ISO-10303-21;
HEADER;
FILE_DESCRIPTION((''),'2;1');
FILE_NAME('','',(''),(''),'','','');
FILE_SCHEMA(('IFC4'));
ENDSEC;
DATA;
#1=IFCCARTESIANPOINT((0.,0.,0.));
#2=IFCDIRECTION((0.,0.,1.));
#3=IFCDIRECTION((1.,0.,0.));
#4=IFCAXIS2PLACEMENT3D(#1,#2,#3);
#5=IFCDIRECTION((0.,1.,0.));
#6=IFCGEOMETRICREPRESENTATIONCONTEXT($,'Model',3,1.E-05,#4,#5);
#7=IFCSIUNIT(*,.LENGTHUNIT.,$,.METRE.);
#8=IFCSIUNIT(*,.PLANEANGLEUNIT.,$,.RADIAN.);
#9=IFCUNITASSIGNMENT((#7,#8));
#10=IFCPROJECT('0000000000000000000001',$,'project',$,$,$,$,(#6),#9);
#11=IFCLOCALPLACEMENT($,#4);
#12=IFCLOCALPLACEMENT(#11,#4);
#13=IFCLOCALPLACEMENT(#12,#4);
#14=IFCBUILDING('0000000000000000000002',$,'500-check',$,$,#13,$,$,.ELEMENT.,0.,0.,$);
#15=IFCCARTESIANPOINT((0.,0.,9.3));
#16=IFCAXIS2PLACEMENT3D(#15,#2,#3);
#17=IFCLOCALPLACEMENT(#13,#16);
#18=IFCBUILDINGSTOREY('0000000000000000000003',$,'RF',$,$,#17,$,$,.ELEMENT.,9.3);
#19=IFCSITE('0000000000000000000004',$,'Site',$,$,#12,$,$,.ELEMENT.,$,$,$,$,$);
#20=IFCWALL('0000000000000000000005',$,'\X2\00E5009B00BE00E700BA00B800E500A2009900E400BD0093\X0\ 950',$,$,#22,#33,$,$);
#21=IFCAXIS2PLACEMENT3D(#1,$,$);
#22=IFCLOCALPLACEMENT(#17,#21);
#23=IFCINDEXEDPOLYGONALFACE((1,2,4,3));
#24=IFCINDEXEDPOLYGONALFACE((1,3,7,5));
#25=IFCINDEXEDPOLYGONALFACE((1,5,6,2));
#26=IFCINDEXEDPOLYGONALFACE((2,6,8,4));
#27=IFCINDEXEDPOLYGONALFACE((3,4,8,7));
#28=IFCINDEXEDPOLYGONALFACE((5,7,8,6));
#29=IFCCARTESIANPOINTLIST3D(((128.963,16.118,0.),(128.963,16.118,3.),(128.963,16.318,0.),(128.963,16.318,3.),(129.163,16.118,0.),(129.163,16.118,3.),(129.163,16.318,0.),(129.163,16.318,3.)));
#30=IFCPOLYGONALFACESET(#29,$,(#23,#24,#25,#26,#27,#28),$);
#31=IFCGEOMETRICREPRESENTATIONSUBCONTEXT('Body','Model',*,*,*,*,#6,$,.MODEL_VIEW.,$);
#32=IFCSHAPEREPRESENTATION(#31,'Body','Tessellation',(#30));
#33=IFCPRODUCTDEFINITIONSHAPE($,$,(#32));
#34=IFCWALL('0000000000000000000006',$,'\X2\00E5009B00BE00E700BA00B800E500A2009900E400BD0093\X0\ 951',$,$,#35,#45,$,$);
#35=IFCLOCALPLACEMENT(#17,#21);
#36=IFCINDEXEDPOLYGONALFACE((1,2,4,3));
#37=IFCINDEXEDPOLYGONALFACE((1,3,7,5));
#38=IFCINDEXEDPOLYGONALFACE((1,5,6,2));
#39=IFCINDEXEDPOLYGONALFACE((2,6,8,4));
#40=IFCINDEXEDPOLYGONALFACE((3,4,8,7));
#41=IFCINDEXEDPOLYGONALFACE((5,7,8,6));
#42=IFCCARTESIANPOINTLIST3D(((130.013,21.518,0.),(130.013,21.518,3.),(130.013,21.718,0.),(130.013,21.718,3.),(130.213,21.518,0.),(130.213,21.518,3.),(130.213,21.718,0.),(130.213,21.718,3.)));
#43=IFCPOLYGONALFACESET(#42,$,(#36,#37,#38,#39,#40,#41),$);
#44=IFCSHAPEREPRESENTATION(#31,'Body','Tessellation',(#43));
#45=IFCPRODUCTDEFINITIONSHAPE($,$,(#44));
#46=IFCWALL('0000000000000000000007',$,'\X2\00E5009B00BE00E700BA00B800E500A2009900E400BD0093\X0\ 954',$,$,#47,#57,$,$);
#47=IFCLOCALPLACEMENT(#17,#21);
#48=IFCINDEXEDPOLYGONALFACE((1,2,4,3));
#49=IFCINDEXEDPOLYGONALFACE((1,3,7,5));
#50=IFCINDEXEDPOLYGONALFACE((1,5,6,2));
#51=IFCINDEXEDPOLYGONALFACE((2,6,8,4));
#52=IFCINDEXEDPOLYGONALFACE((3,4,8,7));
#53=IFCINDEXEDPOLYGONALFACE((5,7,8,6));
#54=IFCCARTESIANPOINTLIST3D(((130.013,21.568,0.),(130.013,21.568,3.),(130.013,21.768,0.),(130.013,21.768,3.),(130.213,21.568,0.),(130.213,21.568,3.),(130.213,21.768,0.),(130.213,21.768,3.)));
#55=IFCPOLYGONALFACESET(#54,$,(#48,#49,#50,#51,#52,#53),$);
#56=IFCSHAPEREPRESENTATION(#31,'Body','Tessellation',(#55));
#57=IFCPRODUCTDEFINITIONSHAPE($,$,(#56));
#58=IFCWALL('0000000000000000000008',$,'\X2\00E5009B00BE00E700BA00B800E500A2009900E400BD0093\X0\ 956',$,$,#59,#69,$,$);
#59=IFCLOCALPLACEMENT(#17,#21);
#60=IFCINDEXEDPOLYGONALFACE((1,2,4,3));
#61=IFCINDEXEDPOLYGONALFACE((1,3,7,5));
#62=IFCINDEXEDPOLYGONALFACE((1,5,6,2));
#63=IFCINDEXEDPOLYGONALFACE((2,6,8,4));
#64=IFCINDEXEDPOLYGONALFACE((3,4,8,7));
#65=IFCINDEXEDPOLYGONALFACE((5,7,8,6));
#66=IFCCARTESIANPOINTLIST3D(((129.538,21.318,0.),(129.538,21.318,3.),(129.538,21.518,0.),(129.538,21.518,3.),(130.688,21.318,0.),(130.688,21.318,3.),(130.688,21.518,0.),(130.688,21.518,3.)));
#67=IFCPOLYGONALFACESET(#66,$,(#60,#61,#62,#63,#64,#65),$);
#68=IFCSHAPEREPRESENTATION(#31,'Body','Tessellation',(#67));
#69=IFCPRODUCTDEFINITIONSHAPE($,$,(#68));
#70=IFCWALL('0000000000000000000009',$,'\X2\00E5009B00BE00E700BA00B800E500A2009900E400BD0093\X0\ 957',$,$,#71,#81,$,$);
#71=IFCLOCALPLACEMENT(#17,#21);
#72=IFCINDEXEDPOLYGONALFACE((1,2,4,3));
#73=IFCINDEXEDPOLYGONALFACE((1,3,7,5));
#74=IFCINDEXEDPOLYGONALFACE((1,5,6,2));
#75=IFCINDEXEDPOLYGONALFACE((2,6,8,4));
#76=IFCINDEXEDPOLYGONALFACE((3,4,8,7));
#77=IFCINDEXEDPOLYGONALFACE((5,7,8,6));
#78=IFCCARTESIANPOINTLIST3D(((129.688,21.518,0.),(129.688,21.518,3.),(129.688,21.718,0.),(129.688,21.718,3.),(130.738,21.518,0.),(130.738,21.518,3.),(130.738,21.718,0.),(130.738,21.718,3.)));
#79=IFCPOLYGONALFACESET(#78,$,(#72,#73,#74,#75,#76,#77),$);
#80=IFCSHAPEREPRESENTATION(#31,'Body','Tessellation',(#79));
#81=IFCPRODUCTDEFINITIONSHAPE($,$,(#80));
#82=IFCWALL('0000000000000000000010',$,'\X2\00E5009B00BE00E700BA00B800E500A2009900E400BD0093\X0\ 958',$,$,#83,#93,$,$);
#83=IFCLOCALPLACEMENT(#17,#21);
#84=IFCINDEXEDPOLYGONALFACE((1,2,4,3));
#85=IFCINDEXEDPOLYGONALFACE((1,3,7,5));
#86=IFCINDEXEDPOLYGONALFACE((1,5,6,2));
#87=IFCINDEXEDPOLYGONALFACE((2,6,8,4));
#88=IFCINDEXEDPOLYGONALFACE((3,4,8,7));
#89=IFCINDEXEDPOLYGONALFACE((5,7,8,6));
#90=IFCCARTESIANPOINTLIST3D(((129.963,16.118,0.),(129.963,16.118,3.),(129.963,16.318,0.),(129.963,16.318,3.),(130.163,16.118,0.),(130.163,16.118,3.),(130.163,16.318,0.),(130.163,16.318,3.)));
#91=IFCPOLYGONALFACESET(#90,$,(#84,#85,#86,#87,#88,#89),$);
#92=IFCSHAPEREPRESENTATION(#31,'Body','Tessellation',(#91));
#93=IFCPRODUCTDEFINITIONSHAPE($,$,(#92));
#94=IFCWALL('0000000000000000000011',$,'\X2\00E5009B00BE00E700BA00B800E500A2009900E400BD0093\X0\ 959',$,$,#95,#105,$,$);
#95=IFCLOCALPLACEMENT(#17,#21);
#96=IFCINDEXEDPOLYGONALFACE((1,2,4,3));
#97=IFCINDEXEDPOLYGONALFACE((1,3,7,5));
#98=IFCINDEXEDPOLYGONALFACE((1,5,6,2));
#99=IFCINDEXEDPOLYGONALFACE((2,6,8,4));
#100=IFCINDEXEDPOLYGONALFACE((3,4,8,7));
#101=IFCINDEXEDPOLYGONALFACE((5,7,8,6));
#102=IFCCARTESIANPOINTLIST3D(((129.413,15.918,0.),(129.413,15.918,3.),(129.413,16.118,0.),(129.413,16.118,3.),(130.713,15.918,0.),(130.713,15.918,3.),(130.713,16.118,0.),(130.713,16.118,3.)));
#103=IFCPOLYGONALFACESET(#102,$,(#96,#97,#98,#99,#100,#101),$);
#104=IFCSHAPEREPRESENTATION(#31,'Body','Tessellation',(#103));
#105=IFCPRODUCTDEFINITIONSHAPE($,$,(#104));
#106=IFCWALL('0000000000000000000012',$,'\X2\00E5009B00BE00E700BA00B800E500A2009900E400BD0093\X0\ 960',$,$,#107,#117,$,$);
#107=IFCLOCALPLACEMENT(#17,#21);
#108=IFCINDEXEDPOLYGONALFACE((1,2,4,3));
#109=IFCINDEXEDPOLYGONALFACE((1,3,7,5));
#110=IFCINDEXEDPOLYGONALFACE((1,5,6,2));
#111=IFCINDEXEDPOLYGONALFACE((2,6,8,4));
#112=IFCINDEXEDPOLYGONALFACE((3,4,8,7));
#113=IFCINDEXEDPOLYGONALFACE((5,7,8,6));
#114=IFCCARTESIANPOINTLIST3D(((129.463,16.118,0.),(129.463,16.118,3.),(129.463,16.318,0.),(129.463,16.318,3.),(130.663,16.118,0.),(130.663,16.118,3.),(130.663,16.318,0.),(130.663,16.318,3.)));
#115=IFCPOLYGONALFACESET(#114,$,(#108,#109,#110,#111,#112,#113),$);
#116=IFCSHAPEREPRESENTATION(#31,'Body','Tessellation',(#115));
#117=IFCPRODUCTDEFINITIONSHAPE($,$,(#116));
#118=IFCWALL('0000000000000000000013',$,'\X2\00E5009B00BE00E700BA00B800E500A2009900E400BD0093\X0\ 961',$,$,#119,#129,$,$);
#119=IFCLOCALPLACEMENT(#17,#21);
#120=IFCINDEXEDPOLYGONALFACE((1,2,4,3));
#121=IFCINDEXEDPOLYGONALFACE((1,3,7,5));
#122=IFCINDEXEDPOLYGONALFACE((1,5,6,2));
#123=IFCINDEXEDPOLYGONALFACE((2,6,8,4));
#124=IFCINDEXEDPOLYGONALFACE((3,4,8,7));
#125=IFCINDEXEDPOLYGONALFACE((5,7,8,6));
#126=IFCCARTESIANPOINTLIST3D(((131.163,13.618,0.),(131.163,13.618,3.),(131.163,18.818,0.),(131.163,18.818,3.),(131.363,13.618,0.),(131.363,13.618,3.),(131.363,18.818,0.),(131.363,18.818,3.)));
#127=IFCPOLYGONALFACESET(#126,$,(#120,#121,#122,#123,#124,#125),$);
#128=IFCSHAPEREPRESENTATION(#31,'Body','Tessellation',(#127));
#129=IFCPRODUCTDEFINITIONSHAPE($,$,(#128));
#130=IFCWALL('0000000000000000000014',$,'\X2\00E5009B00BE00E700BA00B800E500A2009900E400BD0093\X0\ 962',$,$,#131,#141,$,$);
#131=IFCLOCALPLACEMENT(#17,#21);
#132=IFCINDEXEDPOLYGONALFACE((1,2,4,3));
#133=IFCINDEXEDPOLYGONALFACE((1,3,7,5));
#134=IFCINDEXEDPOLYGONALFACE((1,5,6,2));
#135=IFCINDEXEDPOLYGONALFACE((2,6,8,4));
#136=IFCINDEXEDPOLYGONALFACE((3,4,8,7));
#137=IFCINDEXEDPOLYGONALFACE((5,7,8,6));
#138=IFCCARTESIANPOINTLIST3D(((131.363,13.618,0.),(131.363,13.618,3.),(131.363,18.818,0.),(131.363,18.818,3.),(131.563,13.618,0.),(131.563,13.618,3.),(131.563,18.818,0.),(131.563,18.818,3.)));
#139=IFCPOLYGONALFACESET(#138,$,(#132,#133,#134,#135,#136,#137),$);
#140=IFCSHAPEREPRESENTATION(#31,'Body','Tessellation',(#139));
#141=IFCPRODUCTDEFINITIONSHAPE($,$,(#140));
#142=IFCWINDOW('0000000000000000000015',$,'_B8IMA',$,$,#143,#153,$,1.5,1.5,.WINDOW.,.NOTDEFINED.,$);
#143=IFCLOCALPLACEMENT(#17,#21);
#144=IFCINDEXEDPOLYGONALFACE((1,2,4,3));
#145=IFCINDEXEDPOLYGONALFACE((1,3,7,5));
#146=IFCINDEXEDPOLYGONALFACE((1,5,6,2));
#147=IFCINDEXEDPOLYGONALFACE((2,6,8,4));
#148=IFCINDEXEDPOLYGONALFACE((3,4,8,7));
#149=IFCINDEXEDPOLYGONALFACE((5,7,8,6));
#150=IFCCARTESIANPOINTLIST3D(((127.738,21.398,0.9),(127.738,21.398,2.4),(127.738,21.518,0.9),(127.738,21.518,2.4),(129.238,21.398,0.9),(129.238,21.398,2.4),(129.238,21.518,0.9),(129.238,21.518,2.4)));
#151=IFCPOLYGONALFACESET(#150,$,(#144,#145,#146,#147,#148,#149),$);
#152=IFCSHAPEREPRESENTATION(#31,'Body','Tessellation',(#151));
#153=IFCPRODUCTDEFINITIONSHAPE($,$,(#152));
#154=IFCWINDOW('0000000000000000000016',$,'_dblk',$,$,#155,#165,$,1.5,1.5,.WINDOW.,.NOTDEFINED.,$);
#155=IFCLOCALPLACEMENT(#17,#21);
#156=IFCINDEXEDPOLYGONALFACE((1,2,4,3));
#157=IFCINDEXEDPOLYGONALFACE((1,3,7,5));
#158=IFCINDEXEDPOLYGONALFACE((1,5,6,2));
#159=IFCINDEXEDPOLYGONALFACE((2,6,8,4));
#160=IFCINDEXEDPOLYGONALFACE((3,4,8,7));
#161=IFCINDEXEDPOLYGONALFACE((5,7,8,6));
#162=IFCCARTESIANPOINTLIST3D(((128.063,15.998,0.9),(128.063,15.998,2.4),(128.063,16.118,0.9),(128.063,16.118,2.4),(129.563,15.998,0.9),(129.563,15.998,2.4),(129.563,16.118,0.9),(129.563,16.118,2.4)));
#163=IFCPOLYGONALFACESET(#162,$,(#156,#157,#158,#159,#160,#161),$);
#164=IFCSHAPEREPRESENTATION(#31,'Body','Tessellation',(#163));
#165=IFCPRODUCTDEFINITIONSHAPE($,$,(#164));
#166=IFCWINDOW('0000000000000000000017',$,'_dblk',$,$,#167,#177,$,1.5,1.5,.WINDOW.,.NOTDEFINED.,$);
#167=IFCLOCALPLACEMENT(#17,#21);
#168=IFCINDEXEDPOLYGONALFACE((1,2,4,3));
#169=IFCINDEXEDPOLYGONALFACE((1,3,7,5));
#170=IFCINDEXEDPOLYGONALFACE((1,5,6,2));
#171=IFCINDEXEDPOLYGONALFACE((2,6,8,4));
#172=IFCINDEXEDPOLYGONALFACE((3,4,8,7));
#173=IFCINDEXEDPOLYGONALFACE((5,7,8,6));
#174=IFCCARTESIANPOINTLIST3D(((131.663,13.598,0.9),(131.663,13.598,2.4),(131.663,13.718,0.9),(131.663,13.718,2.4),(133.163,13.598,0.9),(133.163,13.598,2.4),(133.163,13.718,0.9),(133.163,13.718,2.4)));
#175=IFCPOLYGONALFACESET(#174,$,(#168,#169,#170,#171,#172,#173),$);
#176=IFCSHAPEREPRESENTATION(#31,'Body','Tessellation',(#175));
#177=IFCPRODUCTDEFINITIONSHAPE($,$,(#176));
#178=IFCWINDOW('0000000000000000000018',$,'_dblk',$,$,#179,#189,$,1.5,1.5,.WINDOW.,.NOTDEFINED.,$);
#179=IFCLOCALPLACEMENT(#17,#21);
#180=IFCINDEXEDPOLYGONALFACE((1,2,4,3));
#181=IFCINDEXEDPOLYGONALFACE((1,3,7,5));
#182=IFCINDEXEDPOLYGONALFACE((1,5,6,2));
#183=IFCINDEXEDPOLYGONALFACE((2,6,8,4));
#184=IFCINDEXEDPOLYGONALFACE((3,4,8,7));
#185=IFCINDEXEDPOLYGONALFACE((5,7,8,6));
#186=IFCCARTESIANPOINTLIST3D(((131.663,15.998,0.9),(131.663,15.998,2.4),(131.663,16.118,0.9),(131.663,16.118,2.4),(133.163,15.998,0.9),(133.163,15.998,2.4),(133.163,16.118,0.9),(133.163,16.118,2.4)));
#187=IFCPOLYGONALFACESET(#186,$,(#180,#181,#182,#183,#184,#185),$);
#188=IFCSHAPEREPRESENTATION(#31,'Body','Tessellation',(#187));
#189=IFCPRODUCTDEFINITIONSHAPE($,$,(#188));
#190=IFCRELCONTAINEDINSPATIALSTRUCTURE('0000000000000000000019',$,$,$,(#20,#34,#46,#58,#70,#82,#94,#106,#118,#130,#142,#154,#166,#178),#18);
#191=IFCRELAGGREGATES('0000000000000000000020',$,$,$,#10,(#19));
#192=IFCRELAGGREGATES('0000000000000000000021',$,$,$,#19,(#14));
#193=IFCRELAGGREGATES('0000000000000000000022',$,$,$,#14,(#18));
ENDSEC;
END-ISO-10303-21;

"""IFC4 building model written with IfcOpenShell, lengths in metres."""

from ifc_helpers import new_model, si_unit, direction, frame, frame_2d, origin_with_axes, place, context, subcontext, project, spatial, rectangle, extrude, element, save


model = new_model("IFC4")

# Units and contexts
model_context = context("Model", 3, precision=1e-05, world=origin_with_axes(), true_north=direction((0.0, 1.0, 0.0)))
body_context = subcontext(model_context, "Body", "Model", "MODEL_VIEW")
ifc_project = project(units=[si_unit("LENGTHUNIT", "METRE"), si_unit("PLANEANGLEUNIT", "RADIAN")], contexts=[model_context])

# Site, building, storey
placement = place(None, origin_with_axes())
site_placement = place(placement, origin_with_axes())
site = spatial("IfcSite", under=ifc_project, at=site_placement, Name="Site", CompositionType="ELEMENT")
building_placement = place(site_placement, origin_with_axes())
building = spatial("IfcBuilding", under=site, at=building_placement, Name="500-check", CompositionType="ELEMENT", ElevationOfRefHeight=0.0, ElevationOfTerrain=0.0)
storey_placement = place(building_placement, frame((0.0, 0.0, 9.3), z_axis=(0.0, 0.0, 1.0), x_axis=(1.0, 0.0, 0.0)))
storey = spatial("IfcBuildingStorey", under=building, at=storey_placement, Name="RF", CompositionType="ELEMENT", Elevation=9.3)

# Walls
for number, where, z_axis, x_axis, name in (
    (1, (129.063, 16.218, 0.0), (0.0, 0.0, 1.0), (0.0, -1.0, 0.0), "å\u009b¾çº¸å¢\u0099ä½\u0093 950"),
    (2, (130.113, 21.618, 0.0), (0.0, 0.0, 1.0), (0.0, -1.0, 0.0), "å\u009b¾çº¸å¢\u0099ä½\u0093 951"),
    (3, (130.113, 21.668, 0.0), (0.0, 0.0, 1.0), (0.0, -1.0, 0.0), "å\u009b¾çº¸å¢\u0099ä½\u0093 954"),
):
    element("IfcWall", number, at=place(storey_placement, frame(where, z_axis=z_axis, x_axis=x_axis)), inside=storey, Name=name, context=body_context, shape_type="SweptSolid", body=[
        extrude(rectangle(XDim=0.2, YDim=0.2, at=frame_2d((0.0, 0.0), x_axis=(1.0, 0.0, 0.0))), frame((0.0, 0.0, 0.0), z_axis=(0.0, 0.0, 1.0)), (0.0, 0.0, 1.0), 3.0),
    ])
wall_1_placement = place(storey_placement, frame((130.113, 21.418, 0.0), z_axis=(0.0, 0.0, 1.0), x_axis=(1.0, 0.0, 0.0)))
element("IfcWall", 4, at=wall_1_placement, inside=storey, Name="å\u009b¾çº¸å¢\u0099ä½\u0093 956", context=body_context, shape_type="SweptSolid", body=[
    extrude(rectangle(XDim=1.15, YDim=0.2, at=frame_2d((0.0, 0.0), x_axis=(1.0, 0.0, 0.0))), frame((0.0, 0.0, 0.0), z_axis=(0.0, 0.0, 1.0)), (0.0, 0.0, 1.0), 3.0),
])
wall_2_placement = place(storey_placement, frame((130.213, 21.618, 0.0), z_axis=(0.0, 0.0, 1.0), x_axis=(1.0, 0.0, 0.0)))
element("IfcWall", 5, at=wall_2_placement, inside=storey, Name="å\u009b¾çº¸å¢\u0099ä½\u0093 957", context=body_context, shape_type="SweptSolid", body=[
    extrude(rectangle(XDim=1.05, YDim=0.2, at=frame_2d((0.0, 0.0), x_axis=(1.0, 0.0, 0.0))), frame((0.0, 0.0, 0.0), z_axis=(0.0, 0.0, 1.0)), (0.0, 0.0, 1.0), 3.0),
])
wall_3_placement = place(storey_placement, frame((130.063, 16.218, 0.0), z_axis=(0.0, 0.0, 1.0), x_axis=(0.0, -1.0, 0.0)))
element("IfcWall", 6, at=wall_3_placement, inside=storey, Name="å\u009b¾çº¸å¢\u0099ä½\u0093 958", context=body_context, shape_type="SweptSolid", body=[
    extrude(rectangle(XDim=0.2, YDim=0.2, at=frame_2d((0.0, 0.0), x_axis=(1.0, 0.0, 0.0))), frame((0.0, 0.0, 0.0), z_axis=(0.0, 0.0, 1.0)), (0.0, 0.0, 1.0), 3.0),
])
wall_4_placement = place(storey_placement, frame((130.063, 16.018, 0.0), z_axis=(0.0, 0.0, 1.0), x_axis=(1.0, 0.0, 0.0)))
element("IfcWall", 7, at=wall_4_placement, inside=storey, Name="å\u009b¾çº¸å¢\u0099ä½\u0093 959", context=body_context, shape_type="SweptSolid", body=[
    extrude(rectangle(XDim=1.3, YDim=0.2, at=frame_2d((0.0, 0.0), x_axis=(1.0, 0.0, 0.0))), frame((0.0, 0.0, 0.0), z_axis=(0.0, 0.0, 1.0)), (0.0, 0.0, 1.0), 3.0),
])
wall_5_placement = place(storey_placement, frame((130.063, 16.218, 0.0), z_axis=(0.0, 0.0, 1.0), x_axis=(1.0, 0.0, 0.0)))
element("IfcWall", 8, at=wall_5_placement, inside=storey, Name="å\u009b¾çº¸å¢\u0099ä½\u0093 960", context=body_context, shape_type="SweptSolid", body=[
    extrude(rectangle(XDim=1.2, YDim=0.2, at=frame_2d((0.0, 0.0), x_axis=(1.0, 0.0, 0.0))), frame((0.0, 0.0, 0.0), z_axis=(0.0, 0.0, 1.0)), (0.0, 0.0, 1.0), 3.0),
])
for number, where, z_axis, x_axis, name in (
    (9, (131.263, 16.218, 0.0), (0.0, 0.0, 1.0), (0.0, 1.0, 0.0), "å\u009b¾çº¸å¢\u0099ä½\u0093 961"),
    (10, (131.463, 16.218, 0.0), (0.0, 0.0, 1.0), (0.0, 1.0, 0.0), "å\u009b¾çº¸å¢\u0099ä½\u0093 962"),
):
    element("IfcWall", number, at=place(storey_placement, frame(where, z_axis=z_axis, x_axis=x_axis)), inside=storey, Name=name, context=body_context, shape_type="SweptSolid", body=[
        extrude(rectangle(XDim=5.2, YDim=0.2, at=frame_2d((0.0, 0.0), x_axis=(1.0, 0.0, 0.0))), frame((0.0, 0.0, 0.0), z_axis=(0.0, 0.0, 1.0)), (0.0, 0.0, 1.0), 3.0),
    ])

# Windows
for number, where, z_axis, x_axis, name in (
    (11, (128.488, 21.458, 0.9), (0.0, 0.0, 1.0), (1.0, 0.0, 0.0), "_B8IMA"),
    (12, (128.813, 16.058, 0.9), (0.0, 0.0, 1.0), (1.0, 0.0, 0.0), "_dblk"),
    (13, (132.413, 13.658, 0.9), (0.0, 0.0, 1.0), (1.0, 0.0, 0.0), "_dblk"),
    (14, (132.413, 16.058, 0.9), (0.0, 0.0, 1.0), (1.0, 0.0, 0.0), "_dblk"),
):
    element("IfcWindow", number, at=place(storey_placement, frame(where, z_axis=z_axis, x_axis=x_axis)), inside=storey, Name=name, OverallHeight=1.5, OverallWidth=1.5, PartitioningType="NOTDEFINED", PredefinedType="WINDOW", context=body_context, shape_type="SweptSolid", body=[
        extrude(rectangle(XDim=1.5, YDim=0.12, at=frame_2d((0.0, 0.0), x_axis=(1.0, 0.0, 0.0))), frame((0.0, 0.0, 0.0), z_axis=(0.0, 0.0, 1.0)), (0.0, 0.0, 1.0), 1.5),
    ])

save(model, "model.ifc")
